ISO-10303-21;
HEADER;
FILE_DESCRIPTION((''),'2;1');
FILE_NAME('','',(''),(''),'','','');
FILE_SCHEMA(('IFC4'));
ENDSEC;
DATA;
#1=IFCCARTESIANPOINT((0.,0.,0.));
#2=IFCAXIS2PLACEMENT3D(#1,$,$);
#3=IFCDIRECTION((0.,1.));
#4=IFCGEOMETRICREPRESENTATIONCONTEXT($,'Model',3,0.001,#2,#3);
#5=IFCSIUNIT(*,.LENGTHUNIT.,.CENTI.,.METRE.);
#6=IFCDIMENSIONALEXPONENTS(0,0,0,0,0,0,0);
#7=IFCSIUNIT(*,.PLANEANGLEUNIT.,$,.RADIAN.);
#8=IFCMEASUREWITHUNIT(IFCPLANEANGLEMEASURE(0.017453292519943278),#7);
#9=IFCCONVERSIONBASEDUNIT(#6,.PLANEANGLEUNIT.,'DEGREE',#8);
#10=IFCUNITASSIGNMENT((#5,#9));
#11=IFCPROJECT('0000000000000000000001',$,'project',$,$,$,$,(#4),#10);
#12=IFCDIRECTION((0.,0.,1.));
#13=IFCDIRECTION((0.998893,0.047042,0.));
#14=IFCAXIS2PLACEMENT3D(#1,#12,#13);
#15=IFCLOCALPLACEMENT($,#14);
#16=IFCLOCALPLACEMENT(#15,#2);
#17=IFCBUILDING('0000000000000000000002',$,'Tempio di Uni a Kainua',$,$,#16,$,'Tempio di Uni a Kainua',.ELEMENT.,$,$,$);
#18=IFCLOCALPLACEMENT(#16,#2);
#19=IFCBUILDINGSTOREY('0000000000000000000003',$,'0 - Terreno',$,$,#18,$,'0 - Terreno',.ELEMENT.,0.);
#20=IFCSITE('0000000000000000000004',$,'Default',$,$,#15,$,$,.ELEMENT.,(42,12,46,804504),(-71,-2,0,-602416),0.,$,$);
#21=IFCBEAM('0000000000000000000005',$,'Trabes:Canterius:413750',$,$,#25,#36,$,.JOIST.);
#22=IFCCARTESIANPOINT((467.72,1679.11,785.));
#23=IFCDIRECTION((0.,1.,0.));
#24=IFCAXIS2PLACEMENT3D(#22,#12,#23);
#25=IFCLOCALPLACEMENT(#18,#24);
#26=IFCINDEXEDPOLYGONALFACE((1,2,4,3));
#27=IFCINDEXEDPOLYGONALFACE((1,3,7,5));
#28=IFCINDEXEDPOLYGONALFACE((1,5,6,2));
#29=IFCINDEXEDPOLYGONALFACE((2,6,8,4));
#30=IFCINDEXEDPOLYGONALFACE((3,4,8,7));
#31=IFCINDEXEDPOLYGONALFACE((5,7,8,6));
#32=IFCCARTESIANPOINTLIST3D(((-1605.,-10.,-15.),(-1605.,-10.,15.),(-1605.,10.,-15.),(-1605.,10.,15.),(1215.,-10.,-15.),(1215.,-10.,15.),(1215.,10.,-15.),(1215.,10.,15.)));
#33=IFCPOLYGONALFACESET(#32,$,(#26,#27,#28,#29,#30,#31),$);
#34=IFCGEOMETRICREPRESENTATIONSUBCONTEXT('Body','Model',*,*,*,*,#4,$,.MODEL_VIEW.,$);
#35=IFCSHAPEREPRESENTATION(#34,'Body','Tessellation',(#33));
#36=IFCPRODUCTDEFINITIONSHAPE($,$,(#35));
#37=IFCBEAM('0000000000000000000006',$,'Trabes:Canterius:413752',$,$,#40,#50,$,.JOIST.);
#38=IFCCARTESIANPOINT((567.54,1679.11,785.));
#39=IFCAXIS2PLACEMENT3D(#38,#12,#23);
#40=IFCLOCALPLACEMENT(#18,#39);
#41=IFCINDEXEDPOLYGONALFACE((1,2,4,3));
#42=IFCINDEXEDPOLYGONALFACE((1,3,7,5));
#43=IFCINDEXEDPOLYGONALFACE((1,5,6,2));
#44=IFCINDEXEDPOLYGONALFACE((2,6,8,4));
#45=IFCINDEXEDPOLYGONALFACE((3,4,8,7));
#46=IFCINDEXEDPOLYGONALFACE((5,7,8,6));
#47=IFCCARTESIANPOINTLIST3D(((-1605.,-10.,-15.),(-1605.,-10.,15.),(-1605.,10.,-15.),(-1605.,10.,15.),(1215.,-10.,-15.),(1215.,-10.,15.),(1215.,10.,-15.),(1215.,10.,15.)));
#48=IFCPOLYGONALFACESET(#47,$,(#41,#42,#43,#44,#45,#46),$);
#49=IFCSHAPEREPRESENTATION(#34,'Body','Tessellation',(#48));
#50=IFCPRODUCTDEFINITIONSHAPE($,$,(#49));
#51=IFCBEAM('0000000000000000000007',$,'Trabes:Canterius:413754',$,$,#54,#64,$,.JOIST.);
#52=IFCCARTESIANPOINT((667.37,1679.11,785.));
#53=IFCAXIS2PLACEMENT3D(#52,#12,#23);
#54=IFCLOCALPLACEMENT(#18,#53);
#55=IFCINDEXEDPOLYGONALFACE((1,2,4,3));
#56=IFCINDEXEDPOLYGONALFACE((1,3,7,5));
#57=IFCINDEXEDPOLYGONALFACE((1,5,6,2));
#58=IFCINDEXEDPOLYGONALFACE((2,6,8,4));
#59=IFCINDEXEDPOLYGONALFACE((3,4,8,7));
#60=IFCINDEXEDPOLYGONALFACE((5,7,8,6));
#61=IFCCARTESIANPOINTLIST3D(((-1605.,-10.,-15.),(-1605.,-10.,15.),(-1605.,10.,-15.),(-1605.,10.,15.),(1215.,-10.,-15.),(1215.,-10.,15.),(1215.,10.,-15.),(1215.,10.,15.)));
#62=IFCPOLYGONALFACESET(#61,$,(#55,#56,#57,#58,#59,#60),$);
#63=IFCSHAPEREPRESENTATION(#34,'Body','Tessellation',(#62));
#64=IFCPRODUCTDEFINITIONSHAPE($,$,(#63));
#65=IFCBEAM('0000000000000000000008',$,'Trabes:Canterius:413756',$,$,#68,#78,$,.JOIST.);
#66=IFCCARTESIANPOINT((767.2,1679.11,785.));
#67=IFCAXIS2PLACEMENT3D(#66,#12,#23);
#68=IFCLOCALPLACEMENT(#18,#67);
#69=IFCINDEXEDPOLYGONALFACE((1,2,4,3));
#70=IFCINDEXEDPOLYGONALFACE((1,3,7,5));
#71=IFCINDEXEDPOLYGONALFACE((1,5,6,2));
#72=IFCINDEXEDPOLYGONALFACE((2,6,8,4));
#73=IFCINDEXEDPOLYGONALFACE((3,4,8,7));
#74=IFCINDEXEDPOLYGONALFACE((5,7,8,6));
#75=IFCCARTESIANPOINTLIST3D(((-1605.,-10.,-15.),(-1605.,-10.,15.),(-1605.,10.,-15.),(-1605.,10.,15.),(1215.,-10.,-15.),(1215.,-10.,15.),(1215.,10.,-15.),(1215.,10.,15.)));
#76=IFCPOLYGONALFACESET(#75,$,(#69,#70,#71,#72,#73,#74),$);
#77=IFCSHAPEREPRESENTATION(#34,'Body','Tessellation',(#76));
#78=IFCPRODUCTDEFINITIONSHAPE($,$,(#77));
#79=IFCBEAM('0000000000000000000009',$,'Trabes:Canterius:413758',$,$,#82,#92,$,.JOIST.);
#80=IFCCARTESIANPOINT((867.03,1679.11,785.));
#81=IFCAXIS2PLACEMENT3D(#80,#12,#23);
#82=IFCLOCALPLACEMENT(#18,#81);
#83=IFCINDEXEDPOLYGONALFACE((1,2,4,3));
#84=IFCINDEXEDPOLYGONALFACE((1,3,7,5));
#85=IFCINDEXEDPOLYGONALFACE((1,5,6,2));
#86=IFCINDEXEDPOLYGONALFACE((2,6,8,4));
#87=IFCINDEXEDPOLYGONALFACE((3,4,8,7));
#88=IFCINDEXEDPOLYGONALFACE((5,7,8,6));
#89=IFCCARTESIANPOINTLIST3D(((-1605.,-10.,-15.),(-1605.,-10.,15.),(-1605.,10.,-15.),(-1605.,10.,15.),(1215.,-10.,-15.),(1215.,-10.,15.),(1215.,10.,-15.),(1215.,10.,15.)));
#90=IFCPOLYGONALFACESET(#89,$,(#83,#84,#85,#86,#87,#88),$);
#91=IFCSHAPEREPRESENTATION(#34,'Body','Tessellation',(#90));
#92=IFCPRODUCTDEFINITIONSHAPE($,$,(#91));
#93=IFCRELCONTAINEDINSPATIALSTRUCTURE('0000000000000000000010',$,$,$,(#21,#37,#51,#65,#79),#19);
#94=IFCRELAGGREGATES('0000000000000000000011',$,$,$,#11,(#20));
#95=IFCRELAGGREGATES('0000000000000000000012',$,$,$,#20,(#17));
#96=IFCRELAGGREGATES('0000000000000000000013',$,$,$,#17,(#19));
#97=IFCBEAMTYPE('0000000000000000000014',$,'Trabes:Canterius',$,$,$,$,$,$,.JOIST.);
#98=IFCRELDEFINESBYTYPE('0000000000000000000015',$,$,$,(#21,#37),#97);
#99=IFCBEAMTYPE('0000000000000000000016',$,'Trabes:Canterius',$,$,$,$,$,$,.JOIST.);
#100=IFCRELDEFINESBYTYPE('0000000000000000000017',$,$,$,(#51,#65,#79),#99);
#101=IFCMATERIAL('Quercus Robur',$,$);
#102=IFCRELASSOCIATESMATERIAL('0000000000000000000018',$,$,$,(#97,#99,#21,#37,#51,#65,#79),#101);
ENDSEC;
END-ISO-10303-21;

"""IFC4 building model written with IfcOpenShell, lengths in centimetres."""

from ifc_helpers import new_model, entity, si_unit, converted_unit, direction, frame, origin, origin_2d_with_axis, place, context, subcontext, project, spatial, rectangle, extrude, source, transform, mapped, material, material_profile, profile_set, profile_usage, type_object, type_shapes, element, save


model = new_model("IFC4")

# Units and contexts
model_context = context("Model", 3, precision=0.001, world=origin(), true_north=direction((0.0, 1.0)))
body_context = subcontext(model_context, "Body", "Model", "MODEL_VIEW")
ifc_project = project(units=[si_unit("LENGTHUNIT", "METRE", prefix="CENTI"), converted_unit("PLANEANGLEUNIT", "DEGREE", entity("IfcPlaneAngleMeasure", 0.017453292519943278), si_unit("PLANEANGLEUNIT", "RADIAN"), dimensions=[0, 0, 0, 0, 0, 0, 0])], contexts=[model_context])

# Site, building, storey
site_placement = place(None, frame((0.0, 0.0, 0.0), z_axis=(0.0, 0.0, 1.0), x_axis=(0.998893, 0.047042, 0.0)))
site = spatial("IfcSite", under=ifc_project, at=site_placement, Name="Default", CompositionType="ELEMENT", RefLatitude=(42, 12, 46, 804504), RefLongitude=(-71, -2, 0, -602416), RefElevation=0.0)
building_placement = place(site_placement, origin())
building = spatial("IfcBuilding", under=site, at=building_placement, Name="Tempio di Uni a Kainua", LongName="Tempio di Uni a Kainua", CompositionType="ELEMENT")
storey_placement = place(building_placement, origin())
storey = spatial("IfcBuildingStorey", under=building, at=storey_placement, Name="0 - Terreno", LongName="0 - Terreno", CompositionType="ELEMENT", Elevation=0.0)

# Beams
ifc_material_1 = material(Name="Quercus Robur")
ifc_material_profile_1 = material_profile(ifc_material_1, rectangle(XDim=2590.0, YDim=20.0, at=origin_2d_with_axis()), Name="Canterius")
ifc_profile_set_1 = profile_set([ifc_material_profile_1], Name="Canterius")
ifc_profile_usage_1 = profile_usage(ifc_profile_set_1, cardinal=1)
beam_type_1 = type_object("IfcBeamType", Name="Trabes:Canterius", PredefinedType="JOIST", material=ifc_profile_set_1)
shared_shape_1 = source(origin(), body_context, "Body", "SweptSolid", [
    extrude(rectangle(XDim=20.0, YDim=2820.0, at=origin_2d_with_axis()), frame((-195.0, 0.0, -15.0), z_axis=(0.0, 0.0, 1.0), x_axis=(0.0, -1.0, 0.0)), (0.0, 0.0, 1.0), 30.0),
])
type_shapes(beam_type_1, [shared_shape_1])
for number, where, z_axis, x_axis, name in (
    (1, (467.72, 1679.11, 785.0), (0.0, 0.0, 1.0), (0.0, 1.0, 0.0), "Trabes:Canterius:413750"),
    (2, (567.54, 1679.11, 785.0), (0.0, 0.0, 1.0), (0.0, 1.0, 0.0), "Trabes:Canterius:413752"),
):
    element("IfcBeam", number, at=place(storey_placement, frame(where, z_axis=z_axis, x_axis=x_axis)), inside=storey, type_object=beam_type_1, material=ifc_profile_usage_1, Name=name, PredefinedType="JOIST", context=body_context, shape_type="MappedRepresentation", body=[
        mapped(shared_shape_1, transform((0.0, 0.0, 0.0), scale=1.0)),
    ])
beam_type_2 = type_object("IfcBeamType", Name="Trabes:Canterius", PredefinedType="JOIST", material=ifc_profile_set_1)
shared_shape_2 = source(origin(), body_context, "Body", "SweptSolid", [
    extrude(rectangle(XDim=20.0, YDim=2820.0, at=origin_2d_with_axis()), frame((-195.0, 0.0, -15.0), z_axis=(0.0, 0.0, 1.0), x_axis=(0.0, -1.0, 0.0)), (0.0, 0.0, 1.0), 30.0),
])
type_shapes(beam_type_2, [shared_shape_2])
for number, where, z_axis, x_axis, name in (
    (3, (667.37, 1679.11, 785.0), (0.0, 0.0, 1.0), (0.0, 1.0, 0.0), "Trabes:Canterius:413754"),
    (4, (767.2, 1679.11, 785.0), (0.0, 0.0, 1.0), (0.0, 1.0, 0.0), "Trabes:Canterius:413756"),
    (5, (867.03, 1679.11, 785.0), (0.0, 0.0, 1.0), (0.0, 1.0, 0.0), "Trabes:Canterius:413758"),
):
    element("IfcBeam", number, at=place(storey_placement, frame(where, z_axis=z_axis, x_axis=x_axis)), inside=storey, type_object=beam_type_2, material=ifc_profile_usage_1, Name=name, PredefinedType="JOIST", context=body_context, shape_type="MappedRepresentation", body=[
        mapped(shared_shape_2, transform((0.0, 0.0, 0.0), scale=1.0)),
    ])

save(model, "model.ifc")
